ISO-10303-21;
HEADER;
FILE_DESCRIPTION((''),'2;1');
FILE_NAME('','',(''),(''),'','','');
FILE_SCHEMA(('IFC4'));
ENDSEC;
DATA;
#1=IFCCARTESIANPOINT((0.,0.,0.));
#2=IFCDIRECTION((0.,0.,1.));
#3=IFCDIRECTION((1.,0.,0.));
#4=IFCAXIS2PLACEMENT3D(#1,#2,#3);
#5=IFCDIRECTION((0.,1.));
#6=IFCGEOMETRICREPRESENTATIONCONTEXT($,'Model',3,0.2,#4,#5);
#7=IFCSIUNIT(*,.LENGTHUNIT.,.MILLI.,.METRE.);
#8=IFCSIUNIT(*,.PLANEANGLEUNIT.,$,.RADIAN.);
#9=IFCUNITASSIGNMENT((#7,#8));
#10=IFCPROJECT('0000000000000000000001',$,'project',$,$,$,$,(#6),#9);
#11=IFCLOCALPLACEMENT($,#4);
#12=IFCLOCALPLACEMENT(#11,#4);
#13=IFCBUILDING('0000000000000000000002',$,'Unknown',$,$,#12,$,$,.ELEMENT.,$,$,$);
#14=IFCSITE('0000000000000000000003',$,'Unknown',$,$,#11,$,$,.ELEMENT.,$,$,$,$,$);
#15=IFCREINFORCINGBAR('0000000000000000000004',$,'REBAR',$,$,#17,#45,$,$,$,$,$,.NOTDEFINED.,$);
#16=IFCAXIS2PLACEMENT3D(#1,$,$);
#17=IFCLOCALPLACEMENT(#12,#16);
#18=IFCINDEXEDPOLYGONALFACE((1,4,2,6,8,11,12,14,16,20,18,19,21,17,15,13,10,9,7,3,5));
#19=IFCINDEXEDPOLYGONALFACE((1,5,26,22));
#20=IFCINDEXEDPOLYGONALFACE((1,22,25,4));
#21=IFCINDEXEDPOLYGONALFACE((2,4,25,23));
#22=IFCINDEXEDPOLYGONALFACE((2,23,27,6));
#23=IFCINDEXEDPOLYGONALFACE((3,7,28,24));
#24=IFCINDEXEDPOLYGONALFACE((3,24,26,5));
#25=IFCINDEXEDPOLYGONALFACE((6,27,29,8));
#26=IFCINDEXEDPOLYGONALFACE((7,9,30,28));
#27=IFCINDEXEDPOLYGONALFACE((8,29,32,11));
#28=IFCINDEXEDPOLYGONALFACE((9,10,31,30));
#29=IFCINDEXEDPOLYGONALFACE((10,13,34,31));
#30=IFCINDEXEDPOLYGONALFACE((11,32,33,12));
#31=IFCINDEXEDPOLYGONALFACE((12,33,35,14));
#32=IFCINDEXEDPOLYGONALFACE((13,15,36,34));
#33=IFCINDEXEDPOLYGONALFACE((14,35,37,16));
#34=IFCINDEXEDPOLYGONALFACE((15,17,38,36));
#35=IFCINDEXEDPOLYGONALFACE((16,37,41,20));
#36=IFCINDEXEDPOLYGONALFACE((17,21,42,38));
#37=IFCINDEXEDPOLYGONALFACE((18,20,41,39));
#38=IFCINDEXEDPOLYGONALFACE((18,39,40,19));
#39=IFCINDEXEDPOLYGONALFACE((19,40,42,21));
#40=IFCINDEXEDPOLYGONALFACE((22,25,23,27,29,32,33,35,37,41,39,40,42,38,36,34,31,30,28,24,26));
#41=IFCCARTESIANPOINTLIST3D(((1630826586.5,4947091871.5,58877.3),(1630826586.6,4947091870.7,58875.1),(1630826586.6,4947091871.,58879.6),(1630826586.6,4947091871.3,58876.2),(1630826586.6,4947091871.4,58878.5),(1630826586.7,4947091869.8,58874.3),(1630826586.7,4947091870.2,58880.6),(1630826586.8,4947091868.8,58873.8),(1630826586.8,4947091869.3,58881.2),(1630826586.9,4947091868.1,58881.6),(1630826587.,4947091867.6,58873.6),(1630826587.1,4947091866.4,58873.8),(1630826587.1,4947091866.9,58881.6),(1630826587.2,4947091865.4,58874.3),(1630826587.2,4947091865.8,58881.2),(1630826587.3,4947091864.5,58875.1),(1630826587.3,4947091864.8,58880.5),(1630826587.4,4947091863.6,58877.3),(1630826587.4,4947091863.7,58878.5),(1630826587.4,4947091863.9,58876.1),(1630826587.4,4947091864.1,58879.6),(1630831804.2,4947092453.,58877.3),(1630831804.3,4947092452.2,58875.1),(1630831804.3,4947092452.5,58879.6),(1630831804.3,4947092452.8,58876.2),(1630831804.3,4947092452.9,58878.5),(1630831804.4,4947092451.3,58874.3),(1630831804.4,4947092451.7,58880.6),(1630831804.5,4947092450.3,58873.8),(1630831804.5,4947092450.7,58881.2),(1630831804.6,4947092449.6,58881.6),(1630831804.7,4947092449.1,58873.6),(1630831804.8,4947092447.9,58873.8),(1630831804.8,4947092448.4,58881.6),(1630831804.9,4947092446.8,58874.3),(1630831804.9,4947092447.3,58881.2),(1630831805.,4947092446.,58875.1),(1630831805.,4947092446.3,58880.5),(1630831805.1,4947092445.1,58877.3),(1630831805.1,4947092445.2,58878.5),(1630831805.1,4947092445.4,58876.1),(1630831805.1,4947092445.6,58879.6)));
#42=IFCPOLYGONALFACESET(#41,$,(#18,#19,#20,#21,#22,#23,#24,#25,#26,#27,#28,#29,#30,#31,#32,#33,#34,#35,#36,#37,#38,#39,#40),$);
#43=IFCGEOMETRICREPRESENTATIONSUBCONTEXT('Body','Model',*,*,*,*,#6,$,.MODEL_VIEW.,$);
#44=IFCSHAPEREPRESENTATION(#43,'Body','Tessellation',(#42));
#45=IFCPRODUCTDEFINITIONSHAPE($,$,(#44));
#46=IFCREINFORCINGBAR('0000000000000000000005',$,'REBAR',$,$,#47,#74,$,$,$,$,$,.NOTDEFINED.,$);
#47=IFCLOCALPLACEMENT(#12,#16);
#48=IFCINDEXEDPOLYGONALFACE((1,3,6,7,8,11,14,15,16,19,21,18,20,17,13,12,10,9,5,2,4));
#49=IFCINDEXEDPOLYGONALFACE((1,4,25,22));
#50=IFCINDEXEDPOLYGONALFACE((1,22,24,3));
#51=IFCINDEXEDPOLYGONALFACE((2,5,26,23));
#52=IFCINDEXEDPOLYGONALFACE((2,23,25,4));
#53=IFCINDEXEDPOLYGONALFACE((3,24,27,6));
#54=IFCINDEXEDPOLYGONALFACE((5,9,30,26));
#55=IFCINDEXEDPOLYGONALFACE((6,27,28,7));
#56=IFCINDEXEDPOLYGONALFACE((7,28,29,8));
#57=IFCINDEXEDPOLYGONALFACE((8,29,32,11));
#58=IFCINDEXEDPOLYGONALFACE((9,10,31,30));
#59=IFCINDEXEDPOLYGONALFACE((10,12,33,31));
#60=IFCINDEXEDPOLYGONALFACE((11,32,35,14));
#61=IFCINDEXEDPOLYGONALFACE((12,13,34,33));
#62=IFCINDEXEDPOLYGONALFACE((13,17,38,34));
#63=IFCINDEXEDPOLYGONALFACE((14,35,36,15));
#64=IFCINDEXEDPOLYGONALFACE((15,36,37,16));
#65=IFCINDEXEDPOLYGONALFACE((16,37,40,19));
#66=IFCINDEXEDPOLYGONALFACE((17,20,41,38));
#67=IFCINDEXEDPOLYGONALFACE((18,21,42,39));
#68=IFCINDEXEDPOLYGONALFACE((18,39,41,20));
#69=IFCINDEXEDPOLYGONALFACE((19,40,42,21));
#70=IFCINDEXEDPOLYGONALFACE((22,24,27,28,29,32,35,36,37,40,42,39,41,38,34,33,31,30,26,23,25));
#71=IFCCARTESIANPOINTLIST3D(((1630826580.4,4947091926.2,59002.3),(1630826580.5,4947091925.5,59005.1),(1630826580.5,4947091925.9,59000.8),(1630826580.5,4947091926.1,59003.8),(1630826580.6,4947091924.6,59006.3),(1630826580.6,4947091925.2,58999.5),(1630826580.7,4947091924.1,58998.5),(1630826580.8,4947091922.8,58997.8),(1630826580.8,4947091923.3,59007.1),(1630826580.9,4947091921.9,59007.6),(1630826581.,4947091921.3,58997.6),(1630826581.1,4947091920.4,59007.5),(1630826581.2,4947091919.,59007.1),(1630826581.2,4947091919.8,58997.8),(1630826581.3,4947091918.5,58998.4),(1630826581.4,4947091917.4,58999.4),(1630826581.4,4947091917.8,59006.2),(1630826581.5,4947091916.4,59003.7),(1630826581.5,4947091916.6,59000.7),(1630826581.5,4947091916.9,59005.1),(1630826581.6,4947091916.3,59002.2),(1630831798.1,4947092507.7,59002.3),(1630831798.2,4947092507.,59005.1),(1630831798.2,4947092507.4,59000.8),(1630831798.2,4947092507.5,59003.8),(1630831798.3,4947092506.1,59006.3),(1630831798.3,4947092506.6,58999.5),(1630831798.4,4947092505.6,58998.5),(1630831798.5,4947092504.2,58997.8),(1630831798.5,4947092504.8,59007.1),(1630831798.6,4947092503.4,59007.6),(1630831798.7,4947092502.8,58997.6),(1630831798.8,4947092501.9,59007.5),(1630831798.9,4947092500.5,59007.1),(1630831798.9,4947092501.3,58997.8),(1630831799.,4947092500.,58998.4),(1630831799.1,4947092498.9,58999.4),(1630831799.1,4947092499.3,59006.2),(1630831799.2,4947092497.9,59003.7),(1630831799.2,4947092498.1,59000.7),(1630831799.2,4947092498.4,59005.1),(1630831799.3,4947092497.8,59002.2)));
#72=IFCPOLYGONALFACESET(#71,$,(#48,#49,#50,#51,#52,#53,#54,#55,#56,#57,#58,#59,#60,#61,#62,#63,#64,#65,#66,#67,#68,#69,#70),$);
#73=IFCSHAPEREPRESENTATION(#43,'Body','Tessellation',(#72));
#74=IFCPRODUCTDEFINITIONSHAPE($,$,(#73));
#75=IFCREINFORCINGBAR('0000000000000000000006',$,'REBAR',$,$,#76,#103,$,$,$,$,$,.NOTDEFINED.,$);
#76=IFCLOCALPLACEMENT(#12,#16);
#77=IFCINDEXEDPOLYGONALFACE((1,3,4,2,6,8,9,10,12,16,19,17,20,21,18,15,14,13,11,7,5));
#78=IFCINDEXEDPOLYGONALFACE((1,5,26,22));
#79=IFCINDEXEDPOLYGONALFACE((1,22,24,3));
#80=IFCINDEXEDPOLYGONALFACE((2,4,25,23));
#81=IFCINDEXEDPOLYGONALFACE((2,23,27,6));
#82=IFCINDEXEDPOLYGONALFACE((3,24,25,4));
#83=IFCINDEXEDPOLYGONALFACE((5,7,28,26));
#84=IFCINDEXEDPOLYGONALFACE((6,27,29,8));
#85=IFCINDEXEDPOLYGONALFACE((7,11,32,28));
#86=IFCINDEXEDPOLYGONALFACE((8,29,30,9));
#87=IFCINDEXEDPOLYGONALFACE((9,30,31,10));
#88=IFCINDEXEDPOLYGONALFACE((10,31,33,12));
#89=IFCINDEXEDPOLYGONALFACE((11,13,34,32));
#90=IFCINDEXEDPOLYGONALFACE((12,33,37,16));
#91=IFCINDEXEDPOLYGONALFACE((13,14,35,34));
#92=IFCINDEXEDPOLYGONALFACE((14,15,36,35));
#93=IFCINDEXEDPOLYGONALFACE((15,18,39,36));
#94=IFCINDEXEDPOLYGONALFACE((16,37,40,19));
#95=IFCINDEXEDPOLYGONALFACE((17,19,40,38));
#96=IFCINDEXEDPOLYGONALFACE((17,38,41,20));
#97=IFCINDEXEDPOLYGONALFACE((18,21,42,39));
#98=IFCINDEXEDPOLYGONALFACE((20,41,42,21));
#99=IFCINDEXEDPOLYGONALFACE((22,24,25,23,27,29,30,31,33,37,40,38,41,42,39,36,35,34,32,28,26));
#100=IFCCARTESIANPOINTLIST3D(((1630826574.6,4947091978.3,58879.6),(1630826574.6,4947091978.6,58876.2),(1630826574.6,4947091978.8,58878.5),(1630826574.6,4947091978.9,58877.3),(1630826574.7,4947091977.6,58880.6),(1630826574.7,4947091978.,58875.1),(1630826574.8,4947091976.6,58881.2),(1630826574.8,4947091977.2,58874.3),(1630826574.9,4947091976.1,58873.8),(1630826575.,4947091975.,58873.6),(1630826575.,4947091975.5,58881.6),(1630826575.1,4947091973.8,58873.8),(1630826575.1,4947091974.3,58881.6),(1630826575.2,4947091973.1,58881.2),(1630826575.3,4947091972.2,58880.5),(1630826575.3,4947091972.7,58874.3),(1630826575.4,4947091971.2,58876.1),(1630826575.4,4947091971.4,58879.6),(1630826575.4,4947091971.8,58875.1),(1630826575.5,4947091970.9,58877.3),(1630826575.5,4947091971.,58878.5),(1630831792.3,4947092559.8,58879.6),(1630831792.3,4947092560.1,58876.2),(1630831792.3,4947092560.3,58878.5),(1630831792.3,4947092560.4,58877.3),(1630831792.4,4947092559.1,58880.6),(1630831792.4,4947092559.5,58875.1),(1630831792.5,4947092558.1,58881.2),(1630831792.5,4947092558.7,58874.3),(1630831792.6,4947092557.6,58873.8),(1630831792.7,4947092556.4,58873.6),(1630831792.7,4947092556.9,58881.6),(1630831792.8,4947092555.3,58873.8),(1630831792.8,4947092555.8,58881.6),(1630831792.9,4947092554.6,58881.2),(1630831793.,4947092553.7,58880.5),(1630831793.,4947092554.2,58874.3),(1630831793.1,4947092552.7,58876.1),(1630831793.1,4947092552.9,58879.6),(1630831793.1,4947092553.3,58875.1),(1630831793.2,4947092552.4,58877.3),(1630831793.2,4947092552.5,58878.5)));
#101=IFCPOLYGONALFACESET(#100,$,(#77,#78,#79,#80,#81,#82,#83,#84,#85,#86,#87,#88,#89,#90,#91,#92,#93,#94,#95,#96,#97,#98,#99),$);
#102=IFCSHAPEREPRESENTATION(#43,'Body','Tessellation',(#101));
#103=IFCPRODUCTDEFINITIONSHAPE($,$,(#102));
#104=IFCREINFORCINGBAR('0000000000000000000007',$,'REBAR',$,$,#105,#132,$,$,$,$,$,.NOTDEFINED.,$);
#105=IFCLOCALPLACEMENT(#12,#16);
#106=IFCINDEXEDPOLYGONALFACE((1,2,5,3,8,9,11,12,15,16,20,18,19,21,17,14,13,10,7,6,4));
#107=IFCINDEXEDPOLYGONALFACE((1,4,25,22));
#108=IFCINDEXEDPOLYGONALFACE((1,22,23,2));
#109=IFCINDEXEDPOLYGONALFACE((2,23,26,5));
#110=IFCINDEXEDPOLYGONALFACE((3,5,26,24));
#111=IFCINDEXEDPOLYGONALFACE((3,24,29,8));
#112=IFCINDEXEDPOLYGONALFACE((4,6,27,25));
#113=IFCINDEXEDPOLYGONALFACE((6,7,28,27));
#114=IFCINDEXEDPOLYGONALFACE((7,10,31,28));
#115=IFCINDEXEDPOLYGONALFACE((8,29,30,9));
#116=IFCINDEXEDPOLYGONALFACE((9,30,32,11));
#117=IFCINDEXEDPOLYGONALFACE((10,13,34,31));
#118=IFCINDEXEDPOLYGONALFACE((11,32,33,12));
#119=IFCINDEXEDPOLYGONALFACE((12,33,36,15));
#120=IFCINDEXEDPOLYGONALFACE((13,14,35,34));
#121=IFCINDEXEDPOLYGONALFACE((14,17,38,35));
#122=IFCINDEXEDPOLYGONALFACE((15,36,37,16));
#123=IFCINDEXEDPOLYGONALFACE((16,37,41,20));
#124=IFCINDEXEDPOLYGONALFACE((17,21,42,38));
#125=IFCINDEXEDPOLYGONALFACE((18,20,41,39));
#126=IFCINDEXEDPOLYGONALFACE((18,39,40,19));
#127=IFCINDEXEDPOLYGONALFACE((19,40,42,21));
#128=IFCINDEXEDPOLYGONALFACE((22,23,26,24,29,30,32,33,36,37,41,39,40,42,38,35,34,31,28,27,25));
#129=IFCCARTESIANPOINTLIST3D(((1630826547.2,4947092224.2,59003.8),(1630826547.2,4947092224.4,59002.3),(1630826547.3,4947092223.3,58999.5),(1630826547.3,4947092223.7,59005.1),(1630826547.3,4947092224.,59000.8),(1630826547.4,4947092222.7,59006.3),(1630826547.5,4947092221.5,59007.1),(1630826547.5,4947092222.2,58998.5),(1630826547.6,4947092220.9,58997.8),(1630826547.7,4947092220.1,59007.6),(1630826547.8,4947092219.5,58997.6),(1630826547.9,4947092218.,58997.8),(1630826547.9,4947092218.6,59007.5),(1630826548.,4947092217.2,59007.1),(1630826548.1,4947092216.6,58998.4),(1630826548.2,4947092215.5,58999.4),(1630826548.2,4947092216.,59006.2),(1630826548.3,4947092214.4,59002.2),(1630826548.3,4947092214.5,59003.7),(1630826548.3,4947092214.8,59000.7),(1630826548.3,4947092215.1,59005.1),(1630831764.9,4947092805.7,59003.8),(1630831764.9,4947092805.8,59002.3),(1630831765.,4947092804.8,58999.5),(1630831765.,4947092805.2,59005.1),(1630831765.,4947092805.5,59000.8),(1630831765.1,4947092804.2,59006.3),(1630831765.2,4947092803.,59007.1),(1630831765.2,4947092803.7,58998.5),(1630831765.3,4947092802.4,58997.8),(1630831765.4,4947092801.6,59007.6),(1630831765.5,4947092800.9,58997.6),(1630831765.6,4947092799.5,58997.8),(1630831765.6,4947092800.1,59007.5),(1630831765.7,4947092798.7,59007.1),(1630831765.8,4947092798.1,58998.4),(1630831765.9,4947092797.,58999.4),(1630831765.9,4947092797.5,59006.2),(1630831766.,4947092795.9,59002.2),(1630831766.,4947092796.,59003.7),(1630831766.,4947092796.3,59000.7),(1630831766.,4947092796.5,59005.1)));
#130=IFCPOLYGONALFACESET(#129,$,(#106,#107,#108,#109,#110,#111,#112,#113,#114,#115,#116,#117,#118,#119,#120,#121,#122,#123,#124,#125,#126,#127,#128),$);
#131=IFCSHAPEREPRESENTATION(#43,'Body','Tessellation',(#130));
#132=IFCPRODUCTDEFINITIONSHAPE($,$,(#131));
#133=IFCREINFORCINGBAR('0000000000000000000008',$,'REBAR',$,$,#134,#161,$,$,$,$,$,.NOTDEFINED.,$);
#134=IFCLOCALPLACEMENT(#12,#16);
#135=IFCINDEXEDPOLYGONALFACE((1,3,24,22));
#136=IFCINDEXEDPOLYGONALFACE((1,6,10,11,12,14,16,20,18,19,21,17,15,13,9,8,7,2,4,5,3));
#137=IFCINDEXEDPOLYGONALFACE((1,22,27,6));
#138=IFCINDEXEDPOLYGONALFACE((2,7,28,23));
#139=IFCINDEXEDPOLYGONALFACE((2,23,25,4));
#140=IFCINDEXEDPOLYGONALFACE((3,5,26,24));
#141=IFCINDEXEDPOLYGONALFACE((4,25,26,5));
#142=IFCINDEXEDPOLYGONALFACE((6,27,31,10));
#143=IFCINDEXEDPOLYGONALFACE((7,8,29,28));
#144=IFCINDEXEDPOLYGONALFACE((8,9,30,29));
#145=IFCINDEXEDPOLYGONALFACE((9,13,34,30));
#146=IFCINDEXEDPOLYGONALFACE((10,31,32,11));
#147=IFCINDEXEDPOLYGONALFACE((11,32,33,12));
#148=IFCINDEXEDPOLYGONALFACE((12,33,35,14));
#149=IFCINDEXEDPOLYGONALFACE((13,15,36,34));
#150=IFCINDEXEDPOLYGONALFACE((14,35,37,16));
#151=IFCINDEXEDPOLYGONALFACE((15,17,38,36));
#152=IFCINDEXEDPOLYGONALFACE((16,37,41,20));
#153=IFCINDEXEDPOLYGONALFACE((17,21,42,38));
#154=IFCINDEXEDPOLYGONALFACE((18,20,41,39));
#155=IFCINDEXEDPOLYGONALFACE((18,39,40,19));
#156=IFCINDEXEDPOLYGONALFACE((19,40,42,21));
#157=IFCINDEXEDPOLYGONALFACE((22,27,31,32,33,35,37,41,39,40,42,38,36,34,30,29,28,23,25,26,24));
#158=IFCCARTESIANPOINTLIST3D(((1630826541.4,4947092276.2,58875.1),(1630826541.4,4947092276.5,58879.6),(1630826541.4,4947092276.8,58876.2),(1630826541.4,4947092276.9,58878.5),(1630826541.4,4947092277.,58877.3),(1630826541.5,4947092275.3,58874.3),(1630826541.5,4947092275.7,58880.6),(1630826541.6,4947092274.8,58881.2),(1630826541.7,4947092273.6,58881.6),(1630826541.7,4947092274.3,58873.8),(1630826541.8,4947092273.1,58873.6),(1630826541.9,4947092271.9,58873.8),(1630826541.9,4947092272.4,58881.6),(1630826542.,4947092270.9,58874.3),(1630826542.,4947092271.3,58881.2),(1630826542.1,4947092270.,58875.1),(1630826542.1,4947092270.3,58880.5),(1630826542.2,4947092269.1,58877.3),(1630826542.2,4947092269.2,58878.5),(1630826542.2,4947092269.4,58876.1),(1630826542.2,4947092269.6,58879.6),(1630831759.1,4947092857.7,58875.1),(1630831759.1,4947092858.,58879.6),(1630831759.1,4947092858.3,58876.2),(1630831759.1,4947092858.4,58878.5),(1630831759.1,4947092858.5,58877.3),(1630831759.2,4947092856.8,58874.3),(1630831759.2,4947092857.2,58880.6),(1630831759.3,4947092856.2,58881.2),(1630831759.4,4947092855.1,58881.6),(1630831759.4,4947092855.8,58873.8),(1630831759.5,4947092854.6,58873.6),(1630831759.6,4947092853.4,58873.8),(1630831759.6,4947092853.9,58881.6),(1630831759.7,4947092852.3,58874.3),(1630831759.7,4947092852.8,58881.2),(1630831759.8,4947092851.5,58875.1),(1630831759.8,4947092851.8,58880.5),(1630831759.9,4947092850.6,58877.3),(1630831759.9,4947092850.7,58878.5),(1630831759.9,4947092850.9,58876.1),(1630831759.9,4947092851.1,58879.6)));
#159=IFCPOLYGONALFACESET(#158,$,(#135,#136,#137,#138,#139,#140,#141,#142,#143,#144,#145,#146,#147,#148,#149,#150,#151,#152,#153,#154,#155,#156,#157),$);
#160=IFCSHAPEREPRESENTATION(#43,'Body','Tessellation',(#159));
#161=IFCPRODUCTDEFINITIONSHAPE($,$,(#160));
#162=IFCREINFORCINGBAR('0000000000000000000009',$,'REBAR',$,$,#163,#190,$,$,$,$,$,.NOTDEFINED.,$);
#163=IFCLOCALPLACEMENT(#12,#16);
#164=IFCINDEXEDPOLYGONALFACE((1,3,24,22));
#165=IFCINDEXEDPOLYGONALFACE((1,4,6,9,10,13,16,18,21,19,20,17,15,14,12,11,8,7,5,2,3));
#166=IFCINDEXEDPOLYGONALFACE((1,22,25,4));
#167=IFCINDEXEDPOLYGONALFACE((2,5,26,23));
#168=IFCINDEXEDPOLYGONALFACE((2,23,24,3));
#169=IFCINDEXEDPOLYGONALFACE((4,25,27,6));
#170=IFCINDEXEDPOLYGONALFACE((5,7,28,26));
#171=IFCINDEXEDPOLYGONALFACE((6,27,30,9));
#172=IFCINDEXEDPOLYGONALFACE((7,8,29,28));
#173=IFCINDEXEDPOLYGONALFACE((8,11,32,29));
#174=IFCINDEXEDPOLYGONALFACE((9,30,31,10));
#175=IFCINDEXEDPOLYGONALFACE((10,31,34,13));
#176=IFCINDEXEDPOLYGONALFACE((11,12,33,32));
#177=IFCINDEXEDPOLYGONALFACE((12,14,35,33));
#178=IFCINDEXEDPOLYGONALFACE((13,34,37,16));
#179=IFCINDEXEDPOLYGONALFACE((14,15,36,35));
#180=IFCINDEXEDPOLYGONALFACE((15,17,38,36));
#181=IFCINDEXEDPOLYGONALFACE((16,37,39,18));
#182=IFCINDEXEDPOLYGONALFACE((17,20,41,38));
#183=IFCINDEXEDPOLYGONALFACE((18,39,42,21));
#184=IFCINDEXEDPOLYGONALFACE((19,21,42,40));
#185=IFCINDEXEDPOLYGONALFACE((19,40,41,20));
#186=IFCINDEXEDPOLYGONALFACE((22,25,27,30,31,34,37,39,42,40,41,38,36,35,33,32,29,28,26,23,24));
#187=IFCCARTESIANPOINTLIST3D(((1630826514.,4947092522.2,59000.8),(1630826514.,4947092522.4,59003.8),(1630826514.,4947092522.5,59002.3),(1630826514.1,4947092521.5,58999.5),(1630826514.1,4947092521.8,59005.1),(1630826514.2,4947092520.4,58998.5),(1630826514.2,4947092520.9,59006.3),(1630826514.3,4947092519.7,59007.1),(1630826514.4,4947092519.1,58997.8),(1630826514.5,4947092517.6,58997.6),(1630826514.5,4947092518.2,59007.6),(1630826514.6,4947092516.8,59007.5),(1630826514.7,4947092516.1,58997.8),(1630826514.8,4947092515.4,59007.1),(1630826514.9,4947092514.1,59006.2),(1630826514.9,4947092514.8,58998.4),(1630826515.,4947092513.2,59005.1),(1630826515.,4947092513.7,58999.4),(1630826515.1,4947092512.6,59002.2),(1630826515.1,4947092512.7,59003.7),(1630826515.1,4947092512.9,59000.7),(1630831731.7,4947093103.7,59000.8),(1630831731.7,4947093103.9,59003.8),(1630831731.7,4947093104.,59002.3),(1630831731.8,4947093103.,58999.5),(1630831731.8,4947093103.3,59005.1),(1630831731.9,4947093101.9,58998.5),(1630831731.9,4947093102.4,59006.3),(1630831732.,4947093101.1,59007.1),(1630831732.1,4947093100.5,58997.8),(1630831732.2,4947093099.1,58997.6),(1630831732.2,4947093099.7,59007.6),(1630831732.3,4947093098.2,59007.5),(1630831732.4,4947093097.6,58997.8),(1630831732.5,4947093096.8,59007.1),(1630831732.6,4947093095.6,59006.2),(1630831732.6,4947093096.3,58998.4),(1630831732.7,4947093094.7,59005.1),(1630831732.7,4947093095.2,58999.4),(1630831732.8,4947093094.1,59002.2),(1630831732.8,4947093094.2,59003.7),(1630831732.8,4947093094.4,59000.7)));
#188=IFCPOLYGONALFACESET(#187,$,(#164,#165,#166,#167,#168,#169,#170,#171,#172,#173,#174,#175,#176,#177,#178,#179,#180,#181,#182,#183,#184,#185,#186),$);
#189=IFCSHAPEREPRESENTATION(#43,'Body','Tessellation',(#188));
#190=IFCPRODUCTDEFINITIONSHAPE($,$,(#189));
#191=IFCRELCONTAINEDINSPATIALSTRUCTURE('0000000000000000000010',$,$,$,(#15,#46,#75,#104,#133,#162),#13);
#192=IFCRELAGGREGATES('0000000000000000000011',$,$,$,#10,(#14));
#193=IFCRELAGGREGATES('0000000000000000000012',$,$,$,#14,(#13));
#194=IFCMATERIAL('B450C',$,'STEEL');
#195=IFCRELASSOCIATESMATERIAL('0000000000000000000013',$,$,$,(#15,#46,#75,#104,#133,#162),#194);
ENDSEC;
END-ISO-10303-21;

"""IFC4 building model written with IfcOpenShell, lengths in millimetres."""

from ifc_helpers import new_model, entity, si_unit, direction, frame, origin_with_axes, place, context, subcontext, project, spatial, material, element, save


model = new_model("IFC4")

# Units and contexts
model_context = context("Model", 3, precision=0.2, world=origin_with_axes(), true_north=direction((0.0, 1.0)))
body_context = subcontext(model_context, "Body", "Model", "MODEL_VIEW")
ifc_project = project(units=[si_unit("LENGTHUNIT", "METRE", prefix="MILLI"), si_unit("PLANEANGLEUNIT", "RADIAN")], contexts=[model_context])

# Site, building
site_placement = place(None, origin_with_axes())
site = spatial("IfcSite", under=ifc_project, at=site_placement, Name="Unknown", CompositionType="ELEMENT")
building_placement = place(site_placement, origin_with_axes())
building = spatial("IfcBuilding", under=site, at=building_placement, Name="Unknown", CompositionType="ELEMENT")

# Reinforcing bars
ifc_material = material(Name="B450C", Category="STEEL")
reinforcing_bar_1_placement = place(building_placement, frame((1630831804.7, 4947092449.0, 58877.6), z_axis=(0.007106, -0.063762, -0.99794), x_axis=(-0.993847, -0.110757, 0.0)))
element("IfcReinforcingBar", 1, at=reinforcing_bar_1_placement, inside=building, material=ifc_material, Name="REBAR", PredefinedType="NOTDEFINED", context=body_context, shape_type="AdvancedSweptSolid", body=[
    entity("IfcSweptDiskSolid", entity("IfcIndexedPolyCurve", entity("IfcCartesianPointList3D", [[0.0, 0.0, 0.0], [5250.0, 0.0, 0.0]]), [entity("IfcLineIndex", [1, 2])]), 4.0),
])
reinforcing_bar_2_placement = place(building_placement, frame((1630831798.7, 4947092502.7, 59002.6), z_axis=(0.007106, -0.063762, -0.99794), x_axis=(-0.993847, -0.110757, 0.0)))
element("IfcReinforcingBar", 2, at=reinforcing_bar_2_placement, inside=building, material=ifc_material, Name="REBAR", PredefinedType="NOTDEFINED", context=body_context, shape_type="AdvancedSweptSolid", body=[
    entity("IfcSweptDiskSolid", entity("IfcIndexedPolyCurve", entity("IfcCartesianPointList3D", [[0.0, 0.0, 0.0], [5250.0, 0.0, 0.0]]), [entity("IfcLineIndex", [1, 2])]), 5.0),
])
reinforcing_bar_3_placement = place(building_placement, frame((1630831792.7, 4947092556.4, 58877.6), z_axis=(0.007106, -0.063762, -0.99794), x_axis=(-0.993847, -0.110757, 0.0)))
element("IfcReinforcingBar", 3, at=reinforcing_bar_3_placement, inside=building, material=ifc_material, Name="REBAR", PredefinedType="NOTDEFINED", context=body_context, shape_type="AdvancedSweptSolid", body=[
    entity("IfcSweptDiskSolid", entity("IfcIndexedPolyCurve", entity("IfcCartesianPointList3D", [[0.0, 0.0, 0.0], [5250.0, 0.0, 0.0]]), [entity("IfcLineIndex", [1, 2])]), 4.0),
])
reinforcing_bar_4_placement = place(building_placement, frame((1630831765.5, 4947092800.9, 59002.6), z_axis=(0.007106, -0.063762, -0.99794), x_axis=(-0.993847, -0.110757, 0.0)))
element("IfcReinforcingBar", 4, at=reinforcing_bar_4_placement, inside=building, material=ifc_material, Name="REBAR", PredefinedType="NOTDEFINED", context=body_context, shape_type="AdvancedSweptSolid", body=[
    entity("IfcSweptDiskSolid", entity("IfcIndexedPolyCurve", entity("IfcCartesianPointList3D", [[0.0, 0.0, 0.0], [5250.0, 0.0, 0.0]]), [entity("IfcLineIndex", [1, 2])]), 5.0),
])
reinforcing_bar_5_placement = place(building_placement, frame((1630831759.5, 4947092854.5, 58877.6), z_axis=(0.007106, -0.063762, -0.99794), x_axis=(-0.993847, -0.110757, 0.0)))
element("IfcReinforcingBar", 5, at=reinforcing_bar_5_placement, inside=building, material=ifc_material, Name="REBAR", PredefinedType="NOTDEFINED", context=body_context, shape_type="AdvancedSweptSolid", body=[
    entity("IfcSweptDiskSolid", entity("IfcIndexedPolyCurve", entity("IfcCartesianPointList3D", [[0.0, 0.0, 0.0], [5250.0, 0.0, 0.0]]), [entity("IfcLineIndex", [1, 2])]), 4.0),
])
reinforcing_bar_6_placement = place(building_placement, frame((1630831732.2, 4947093099.0, 59002.6), z_axis=(0.007106, -0.063762, -0.99794), x_axis=(-0.993847, -0.110757, 0.0)))
element("IfcReinforcingBar", 6, at=reinforcing_bar_6_placement, inside=building, material=ifc_material, Name="REBAR", PredefinedType="NOTDEFINED", context=body_context, shape_type="AdvancedSweptSolid", body=[
    entity("IfcSweptDiskSolid", entity("IfcIndexedPolyCurve", entity("IfcCartesianPointList3D", [[0.0, 0.0, 0.0], [5250.0, 0.0, 0.0]]), [entity("IfcLineIndex", [1, 2])]), 5.0),
])

save(model, "model.ifc")
